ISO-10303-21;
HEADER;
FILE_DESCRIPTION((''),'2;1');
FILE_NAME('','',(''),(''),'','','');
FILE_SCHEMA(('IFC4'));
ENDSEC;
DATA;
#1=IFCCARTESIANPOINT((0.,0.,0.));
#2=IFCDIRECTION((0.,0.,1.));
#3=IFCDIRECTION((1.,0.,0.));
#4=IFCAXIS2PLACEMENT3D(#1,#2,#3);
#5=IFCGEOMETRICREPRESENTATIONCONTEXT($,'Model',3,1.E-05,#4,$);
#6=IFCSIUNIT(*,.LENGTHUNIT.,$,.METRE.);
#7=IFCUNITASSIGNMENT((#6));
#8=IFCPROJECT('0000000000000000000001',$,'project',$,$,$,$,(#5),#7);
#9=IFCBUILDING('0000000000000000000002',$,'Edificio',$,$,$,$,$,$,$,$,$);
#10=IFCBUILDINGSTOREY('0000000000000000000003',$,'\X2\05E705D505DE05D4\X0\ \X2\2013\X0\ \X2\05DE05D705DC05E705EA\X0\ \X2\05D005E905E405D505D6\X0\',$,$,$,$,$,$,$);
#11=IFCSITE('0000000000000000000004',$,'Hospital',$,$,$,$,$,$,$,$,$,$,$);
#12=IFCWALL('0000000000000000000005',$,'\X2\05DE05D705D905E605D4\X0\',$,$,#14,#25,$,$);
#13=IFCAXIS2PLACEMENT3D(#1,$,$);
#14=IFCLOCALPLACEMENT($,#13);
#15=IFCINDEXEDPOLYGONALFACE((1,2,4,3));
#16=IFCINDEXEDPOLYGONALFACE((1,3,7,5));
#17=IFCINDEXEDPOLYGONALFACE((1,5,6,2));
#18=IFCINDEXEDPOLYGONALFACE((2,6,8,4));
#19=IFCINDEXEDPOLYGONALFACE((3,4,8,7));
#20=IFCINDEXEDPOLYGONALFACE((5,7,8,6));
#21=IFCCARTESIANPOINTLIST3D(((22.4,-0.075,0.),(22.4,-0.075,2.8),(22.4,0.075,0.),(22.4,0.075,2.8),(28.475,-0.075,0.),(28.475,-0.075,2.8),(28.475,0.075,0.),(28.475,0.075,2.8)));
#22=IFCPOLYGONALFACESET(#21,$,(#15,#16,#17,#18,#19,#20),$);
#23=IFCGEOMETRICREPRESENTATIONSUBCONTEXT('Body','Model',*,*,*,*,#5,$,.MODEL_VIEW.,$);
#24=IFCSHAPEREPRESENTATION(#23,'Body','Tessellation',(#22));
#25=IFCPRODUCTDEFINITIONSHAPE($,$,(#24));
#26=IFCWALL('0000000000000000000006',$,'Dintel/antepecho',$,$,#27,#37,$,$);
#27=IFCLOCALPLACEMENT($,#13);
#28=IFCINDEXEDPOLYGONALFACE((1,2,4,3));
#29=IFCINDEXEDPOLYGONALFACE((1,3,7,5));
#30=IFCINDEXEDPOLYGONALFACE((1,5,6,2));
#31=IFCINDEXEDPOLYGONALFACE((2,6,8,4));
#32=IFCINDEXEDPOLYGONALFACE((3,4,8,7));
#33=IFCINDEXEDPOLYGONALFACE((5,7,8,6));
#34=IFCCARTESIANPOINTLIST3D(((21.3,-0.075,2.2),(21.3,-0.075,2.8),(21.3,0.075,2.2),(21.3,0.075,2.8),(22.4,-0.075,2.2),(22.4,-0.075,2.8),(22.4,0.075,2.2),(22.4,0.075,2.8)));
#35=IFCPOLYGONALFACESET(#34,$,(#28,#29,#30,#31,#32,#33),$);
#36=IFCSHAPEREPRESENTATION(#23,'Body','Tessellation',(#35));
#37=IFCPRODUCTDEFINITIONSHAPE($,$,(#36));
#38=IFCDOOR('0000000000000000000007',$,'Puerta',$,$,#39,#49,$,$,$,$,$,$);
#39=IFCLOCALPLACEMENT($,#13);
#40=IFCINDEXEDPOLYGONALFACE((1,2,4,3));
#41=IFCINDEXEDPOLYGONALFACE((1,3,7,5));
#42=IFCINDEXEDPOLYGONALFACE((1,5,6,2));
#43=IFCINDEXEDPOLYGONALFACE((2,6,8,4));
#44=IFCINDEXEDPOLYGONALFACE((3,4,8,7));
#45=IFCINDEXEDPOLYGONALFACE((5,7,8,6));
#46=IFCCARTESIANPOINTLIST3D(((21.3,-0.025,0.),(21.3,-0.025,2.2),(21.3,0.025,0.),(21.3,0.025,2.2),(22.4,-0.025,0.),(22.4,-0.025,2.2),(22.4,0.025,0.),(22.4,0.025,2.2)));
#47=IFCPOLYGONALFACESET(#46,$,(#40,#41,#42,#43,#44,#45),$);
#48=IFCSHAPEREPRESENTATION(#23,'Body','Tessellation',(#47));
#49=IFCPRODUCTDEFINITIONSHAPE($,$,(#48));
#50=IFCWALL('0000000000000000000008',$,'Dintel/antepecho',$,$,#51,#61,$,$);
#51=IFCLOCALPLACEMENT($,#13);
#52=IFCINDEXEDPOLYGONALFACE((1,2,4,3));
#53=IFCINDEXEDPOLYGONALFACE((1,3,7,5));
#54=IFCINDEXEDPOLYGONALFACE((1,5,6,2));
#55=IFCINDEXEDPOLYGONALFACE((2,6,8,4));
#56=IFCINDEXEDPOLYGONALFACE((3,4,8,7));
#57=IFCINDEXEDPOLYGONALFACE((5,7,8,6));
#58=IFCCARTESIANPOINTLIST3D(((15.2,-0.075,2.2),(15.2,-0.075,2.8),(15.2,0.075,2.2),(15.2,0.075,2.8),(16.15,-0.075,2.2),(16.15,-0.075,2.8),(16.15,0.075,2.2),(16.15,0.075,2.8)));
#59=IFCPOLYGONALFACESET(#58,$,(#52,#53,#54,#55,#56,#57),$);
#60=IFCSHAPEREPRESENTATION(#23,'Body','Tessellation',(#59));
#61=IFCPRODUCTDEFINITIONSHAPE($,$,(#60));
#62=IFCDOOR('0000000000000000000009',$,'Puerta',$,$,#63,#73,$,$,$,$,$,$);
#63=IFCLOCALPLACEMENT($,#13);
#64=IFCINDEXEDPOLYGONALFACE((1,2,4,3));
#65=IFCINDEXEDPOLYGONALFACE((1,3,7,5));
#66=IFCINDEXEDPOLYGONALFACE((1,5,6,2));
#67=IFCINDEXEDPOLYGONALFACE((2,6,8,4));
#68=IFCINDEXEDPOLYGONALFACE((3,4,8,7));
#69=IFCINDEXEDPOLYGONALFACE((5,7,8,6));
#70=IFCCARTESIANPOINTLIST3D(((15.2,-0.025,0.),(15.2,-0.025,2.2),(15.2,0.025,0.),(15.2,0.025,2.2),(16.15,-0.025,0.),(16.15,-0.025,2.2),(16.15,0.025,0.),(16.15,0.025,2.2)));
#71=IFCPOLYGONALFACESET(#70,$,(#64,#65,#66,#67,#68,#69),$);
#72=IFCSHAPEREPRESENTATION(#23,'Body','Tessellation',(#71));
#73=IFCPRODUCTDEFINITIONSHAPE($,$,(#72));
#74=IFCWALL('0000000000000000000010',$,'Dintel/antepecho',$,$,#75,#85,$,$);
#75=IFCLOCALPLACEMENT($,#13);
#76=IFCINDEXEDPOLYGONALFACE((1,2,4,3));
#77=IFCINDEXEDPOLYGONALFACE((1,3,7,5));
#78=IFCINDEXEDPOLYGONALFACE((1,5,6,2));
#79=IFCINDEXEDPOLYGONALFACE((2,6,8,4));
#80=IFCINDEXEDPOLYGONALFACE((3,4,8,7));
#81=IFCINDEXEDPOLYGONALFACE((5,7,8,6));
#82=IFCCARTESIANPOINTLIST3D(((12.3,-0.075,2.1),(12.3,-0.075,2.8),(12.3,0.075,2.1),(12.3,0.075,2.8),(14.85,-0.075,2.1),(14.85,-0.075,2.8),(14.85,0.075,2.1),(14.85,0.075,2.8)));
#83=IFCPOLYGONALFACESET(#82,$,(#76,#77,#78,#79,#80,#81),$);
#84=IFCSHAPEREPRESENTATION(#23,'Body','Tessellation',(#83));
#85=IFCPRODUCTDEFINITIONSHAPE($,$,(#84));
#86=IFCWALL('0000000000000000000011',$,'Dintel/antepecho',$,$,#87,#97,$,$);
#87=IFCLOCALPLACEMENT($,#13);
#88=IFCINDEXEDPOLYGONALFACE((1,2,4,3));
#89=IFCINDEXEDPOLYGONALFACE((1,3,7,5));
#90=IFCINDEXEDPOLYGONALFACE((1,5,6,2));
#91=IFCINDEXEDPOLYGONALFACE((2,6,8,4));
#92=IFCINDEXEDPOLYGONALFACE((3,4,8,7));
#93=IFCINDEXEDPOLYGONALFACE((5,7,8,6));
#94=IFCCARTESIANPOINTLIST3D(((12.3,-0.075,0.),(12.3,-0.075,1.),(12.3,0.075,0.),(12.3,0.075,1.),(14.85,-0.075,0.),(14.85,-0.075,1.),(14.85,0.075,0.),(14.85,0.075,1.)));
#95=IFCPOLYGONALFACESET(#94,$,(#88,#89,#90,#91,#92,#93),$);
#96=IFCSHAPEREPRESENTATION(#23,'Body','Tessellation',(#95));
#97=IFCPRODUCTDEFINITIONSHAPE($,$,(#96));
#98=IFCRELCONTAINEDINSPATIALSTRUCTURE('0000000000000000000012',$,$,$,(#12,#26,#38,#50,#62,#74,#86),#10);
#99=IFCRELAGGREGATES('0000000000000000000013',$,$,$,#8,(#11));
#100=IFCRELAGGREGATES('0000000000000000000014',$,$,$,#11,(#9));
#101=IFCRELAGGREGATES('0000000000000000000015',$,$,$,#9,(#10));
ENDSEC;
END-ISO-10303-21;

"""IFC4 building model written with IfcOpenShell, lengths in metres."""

from ifc_helpers import new_model, si_unit, frame, origin_with_axes, context, subcontext, project, spatial, line, indexed_curve, outline, extrude, element, save


model = new_model("IFC4")

# Units and contexts
model_context = context("Model", 3, precision=1e-05, world=origin_with_axes())
body_context = subcontext(model_context, "Body", "Model", "MODEL_VIEW")
ifc_project = project(units=[si_unit("LENGTHUNIT", "METRE")], contexts=[model_context])

# Site, building, storey
site = spatial("IfcSite", under=ifc_project, Name="Hospital")
building = spatial("IfcBuilding", under=site, Name="Edificio")
storey = spatial("IfcBuildingStorey", under=building, Name="קומה – מחלקת אשפוז")

# Walls
element("IfcWall", 1, inside=storey, Name="מחיצה", context=body_context, shape_type="SweptSolid", body=[
    extrude(outline(indexed_curve([(0.0, 0.0), (6.075, 0.0), (6.075, 0.15), (0.0, 0.15)], segments=[line(1, 2, 3, 4, 1)])), frame((22.4, -0.075, 0.0), z_axis=(0.0, 0.0, 1.0), x_axis=(1.0, 0.0, 0.0)), (0.0, 0.0, 1.0), 2.8),
])
element("IfcWall", 2, inside=storey, Name="Dintel/antepecho", context=body_context, shape_type="SweptSolid", body=[
    extrude(outline(indexed_curve([(0.0, 0.0), (1.1, 0.0), (1.1, 0.15), (0.0, 0.15)], segments=[line(1, 2, 3, 4, 1)])), frame((21.3, -0.075, 2.2), z_axis=(0.0, 0.0, 1.0), x_axis=(1.0, 0.0, 0.0)), (0.0, 0.0, 1.0), 0.6),
])

# Door
element("IfcDoor", 3, inside=storey, Name="Puerta", context=body_context, shape_type="SweptSolid", body=[
    extrude(outline(indexed_curve([(0.0, 0.0), (1.1, 0.0), (1.1, 0.05), (0.0, 0.05)], segments=[line(1, 2, 3, 4, 1)])), frame((21.3, -0.025, 0.0), z_axis=(0.0, 0.0, 1.0), x_axis=(1.0, 0.0, 0.0)), (0.0, 0.0, 1.0), 2.2),
])

# Wall
element("IfcWall", 4, inside=storey, Name="Dintel/antepecho", context=body_context, shape_type="SweptSolid", body=[
    extrude(outline(indexed_curve([(0.0, 0.0), (0.95, 0.0), (0.95, 0.15), (0.0, 0.15)], segments=[line(1, 2, 3, 4, 1)])), frame((15.2, -0.075, 2.2), z_axis=(0.0, 0.0, 1.0), x_axis=(1.0, 0.0, 0.0)), (0.0, 0.0, 1.0), 0.6),
])

# Door
element("IfcDoor", 5, inside=storey, Name="Puerta", context=body_context, shape_type="SweptSolid", body=[
    extrude(outline(indexed_curve([(0.0, 0.0), (0.95, 0.0), (0.95, 0.05), (0.0, 0.05)], segments=[line(1, 2, 3, 4, 1)])), frame((15.2, -0.025, 0.0), z_axis=(0.0, 0.0, 1.0), x_axis=(1.0, 0.0, 0.0)), (0.0, 0.0, 1.0), 2.2),
])

# Walls
element("IfcWall", 6, inside=storey, Name="Dintel/antepecho", context=body_context, shape_type="SweptSolid", body=[
    extrude(outline(indexed_curve([(0.0, 0.0), (2.55, 0.0), (2.55, 0.15), (0.0, 0.15)], segments=[line(1, 2, 3, 4, 1)])), frame((12.3, -0.075, 2.1), z_axis=(0.0, 0.0, 1.0), x_axis=(1.0, 0.0, 0.0)), (0.0, 0.0, 1.0), 0.7),
])
element("IfcWall", 7, inside=storey, Name="Dintel/antepecho", context=body_context, shape_type="SweptSolid", body=[
    extrude(outline(indexed_curve([(0.0, 0.0), (2.55, 0.0), (2.55, 0.15), (0.0, 0.15)], segments=[line(1, 2, 3, 4, 1)])), frame((12.3, -0.075, 0.0), z_axis=(0.0, 0.0, 1.0), x_axis=(1.0, 0.0, 0.0)), (0.0, 0.0, 1.0), 1.0),
])

save(model, "model.ifc")
